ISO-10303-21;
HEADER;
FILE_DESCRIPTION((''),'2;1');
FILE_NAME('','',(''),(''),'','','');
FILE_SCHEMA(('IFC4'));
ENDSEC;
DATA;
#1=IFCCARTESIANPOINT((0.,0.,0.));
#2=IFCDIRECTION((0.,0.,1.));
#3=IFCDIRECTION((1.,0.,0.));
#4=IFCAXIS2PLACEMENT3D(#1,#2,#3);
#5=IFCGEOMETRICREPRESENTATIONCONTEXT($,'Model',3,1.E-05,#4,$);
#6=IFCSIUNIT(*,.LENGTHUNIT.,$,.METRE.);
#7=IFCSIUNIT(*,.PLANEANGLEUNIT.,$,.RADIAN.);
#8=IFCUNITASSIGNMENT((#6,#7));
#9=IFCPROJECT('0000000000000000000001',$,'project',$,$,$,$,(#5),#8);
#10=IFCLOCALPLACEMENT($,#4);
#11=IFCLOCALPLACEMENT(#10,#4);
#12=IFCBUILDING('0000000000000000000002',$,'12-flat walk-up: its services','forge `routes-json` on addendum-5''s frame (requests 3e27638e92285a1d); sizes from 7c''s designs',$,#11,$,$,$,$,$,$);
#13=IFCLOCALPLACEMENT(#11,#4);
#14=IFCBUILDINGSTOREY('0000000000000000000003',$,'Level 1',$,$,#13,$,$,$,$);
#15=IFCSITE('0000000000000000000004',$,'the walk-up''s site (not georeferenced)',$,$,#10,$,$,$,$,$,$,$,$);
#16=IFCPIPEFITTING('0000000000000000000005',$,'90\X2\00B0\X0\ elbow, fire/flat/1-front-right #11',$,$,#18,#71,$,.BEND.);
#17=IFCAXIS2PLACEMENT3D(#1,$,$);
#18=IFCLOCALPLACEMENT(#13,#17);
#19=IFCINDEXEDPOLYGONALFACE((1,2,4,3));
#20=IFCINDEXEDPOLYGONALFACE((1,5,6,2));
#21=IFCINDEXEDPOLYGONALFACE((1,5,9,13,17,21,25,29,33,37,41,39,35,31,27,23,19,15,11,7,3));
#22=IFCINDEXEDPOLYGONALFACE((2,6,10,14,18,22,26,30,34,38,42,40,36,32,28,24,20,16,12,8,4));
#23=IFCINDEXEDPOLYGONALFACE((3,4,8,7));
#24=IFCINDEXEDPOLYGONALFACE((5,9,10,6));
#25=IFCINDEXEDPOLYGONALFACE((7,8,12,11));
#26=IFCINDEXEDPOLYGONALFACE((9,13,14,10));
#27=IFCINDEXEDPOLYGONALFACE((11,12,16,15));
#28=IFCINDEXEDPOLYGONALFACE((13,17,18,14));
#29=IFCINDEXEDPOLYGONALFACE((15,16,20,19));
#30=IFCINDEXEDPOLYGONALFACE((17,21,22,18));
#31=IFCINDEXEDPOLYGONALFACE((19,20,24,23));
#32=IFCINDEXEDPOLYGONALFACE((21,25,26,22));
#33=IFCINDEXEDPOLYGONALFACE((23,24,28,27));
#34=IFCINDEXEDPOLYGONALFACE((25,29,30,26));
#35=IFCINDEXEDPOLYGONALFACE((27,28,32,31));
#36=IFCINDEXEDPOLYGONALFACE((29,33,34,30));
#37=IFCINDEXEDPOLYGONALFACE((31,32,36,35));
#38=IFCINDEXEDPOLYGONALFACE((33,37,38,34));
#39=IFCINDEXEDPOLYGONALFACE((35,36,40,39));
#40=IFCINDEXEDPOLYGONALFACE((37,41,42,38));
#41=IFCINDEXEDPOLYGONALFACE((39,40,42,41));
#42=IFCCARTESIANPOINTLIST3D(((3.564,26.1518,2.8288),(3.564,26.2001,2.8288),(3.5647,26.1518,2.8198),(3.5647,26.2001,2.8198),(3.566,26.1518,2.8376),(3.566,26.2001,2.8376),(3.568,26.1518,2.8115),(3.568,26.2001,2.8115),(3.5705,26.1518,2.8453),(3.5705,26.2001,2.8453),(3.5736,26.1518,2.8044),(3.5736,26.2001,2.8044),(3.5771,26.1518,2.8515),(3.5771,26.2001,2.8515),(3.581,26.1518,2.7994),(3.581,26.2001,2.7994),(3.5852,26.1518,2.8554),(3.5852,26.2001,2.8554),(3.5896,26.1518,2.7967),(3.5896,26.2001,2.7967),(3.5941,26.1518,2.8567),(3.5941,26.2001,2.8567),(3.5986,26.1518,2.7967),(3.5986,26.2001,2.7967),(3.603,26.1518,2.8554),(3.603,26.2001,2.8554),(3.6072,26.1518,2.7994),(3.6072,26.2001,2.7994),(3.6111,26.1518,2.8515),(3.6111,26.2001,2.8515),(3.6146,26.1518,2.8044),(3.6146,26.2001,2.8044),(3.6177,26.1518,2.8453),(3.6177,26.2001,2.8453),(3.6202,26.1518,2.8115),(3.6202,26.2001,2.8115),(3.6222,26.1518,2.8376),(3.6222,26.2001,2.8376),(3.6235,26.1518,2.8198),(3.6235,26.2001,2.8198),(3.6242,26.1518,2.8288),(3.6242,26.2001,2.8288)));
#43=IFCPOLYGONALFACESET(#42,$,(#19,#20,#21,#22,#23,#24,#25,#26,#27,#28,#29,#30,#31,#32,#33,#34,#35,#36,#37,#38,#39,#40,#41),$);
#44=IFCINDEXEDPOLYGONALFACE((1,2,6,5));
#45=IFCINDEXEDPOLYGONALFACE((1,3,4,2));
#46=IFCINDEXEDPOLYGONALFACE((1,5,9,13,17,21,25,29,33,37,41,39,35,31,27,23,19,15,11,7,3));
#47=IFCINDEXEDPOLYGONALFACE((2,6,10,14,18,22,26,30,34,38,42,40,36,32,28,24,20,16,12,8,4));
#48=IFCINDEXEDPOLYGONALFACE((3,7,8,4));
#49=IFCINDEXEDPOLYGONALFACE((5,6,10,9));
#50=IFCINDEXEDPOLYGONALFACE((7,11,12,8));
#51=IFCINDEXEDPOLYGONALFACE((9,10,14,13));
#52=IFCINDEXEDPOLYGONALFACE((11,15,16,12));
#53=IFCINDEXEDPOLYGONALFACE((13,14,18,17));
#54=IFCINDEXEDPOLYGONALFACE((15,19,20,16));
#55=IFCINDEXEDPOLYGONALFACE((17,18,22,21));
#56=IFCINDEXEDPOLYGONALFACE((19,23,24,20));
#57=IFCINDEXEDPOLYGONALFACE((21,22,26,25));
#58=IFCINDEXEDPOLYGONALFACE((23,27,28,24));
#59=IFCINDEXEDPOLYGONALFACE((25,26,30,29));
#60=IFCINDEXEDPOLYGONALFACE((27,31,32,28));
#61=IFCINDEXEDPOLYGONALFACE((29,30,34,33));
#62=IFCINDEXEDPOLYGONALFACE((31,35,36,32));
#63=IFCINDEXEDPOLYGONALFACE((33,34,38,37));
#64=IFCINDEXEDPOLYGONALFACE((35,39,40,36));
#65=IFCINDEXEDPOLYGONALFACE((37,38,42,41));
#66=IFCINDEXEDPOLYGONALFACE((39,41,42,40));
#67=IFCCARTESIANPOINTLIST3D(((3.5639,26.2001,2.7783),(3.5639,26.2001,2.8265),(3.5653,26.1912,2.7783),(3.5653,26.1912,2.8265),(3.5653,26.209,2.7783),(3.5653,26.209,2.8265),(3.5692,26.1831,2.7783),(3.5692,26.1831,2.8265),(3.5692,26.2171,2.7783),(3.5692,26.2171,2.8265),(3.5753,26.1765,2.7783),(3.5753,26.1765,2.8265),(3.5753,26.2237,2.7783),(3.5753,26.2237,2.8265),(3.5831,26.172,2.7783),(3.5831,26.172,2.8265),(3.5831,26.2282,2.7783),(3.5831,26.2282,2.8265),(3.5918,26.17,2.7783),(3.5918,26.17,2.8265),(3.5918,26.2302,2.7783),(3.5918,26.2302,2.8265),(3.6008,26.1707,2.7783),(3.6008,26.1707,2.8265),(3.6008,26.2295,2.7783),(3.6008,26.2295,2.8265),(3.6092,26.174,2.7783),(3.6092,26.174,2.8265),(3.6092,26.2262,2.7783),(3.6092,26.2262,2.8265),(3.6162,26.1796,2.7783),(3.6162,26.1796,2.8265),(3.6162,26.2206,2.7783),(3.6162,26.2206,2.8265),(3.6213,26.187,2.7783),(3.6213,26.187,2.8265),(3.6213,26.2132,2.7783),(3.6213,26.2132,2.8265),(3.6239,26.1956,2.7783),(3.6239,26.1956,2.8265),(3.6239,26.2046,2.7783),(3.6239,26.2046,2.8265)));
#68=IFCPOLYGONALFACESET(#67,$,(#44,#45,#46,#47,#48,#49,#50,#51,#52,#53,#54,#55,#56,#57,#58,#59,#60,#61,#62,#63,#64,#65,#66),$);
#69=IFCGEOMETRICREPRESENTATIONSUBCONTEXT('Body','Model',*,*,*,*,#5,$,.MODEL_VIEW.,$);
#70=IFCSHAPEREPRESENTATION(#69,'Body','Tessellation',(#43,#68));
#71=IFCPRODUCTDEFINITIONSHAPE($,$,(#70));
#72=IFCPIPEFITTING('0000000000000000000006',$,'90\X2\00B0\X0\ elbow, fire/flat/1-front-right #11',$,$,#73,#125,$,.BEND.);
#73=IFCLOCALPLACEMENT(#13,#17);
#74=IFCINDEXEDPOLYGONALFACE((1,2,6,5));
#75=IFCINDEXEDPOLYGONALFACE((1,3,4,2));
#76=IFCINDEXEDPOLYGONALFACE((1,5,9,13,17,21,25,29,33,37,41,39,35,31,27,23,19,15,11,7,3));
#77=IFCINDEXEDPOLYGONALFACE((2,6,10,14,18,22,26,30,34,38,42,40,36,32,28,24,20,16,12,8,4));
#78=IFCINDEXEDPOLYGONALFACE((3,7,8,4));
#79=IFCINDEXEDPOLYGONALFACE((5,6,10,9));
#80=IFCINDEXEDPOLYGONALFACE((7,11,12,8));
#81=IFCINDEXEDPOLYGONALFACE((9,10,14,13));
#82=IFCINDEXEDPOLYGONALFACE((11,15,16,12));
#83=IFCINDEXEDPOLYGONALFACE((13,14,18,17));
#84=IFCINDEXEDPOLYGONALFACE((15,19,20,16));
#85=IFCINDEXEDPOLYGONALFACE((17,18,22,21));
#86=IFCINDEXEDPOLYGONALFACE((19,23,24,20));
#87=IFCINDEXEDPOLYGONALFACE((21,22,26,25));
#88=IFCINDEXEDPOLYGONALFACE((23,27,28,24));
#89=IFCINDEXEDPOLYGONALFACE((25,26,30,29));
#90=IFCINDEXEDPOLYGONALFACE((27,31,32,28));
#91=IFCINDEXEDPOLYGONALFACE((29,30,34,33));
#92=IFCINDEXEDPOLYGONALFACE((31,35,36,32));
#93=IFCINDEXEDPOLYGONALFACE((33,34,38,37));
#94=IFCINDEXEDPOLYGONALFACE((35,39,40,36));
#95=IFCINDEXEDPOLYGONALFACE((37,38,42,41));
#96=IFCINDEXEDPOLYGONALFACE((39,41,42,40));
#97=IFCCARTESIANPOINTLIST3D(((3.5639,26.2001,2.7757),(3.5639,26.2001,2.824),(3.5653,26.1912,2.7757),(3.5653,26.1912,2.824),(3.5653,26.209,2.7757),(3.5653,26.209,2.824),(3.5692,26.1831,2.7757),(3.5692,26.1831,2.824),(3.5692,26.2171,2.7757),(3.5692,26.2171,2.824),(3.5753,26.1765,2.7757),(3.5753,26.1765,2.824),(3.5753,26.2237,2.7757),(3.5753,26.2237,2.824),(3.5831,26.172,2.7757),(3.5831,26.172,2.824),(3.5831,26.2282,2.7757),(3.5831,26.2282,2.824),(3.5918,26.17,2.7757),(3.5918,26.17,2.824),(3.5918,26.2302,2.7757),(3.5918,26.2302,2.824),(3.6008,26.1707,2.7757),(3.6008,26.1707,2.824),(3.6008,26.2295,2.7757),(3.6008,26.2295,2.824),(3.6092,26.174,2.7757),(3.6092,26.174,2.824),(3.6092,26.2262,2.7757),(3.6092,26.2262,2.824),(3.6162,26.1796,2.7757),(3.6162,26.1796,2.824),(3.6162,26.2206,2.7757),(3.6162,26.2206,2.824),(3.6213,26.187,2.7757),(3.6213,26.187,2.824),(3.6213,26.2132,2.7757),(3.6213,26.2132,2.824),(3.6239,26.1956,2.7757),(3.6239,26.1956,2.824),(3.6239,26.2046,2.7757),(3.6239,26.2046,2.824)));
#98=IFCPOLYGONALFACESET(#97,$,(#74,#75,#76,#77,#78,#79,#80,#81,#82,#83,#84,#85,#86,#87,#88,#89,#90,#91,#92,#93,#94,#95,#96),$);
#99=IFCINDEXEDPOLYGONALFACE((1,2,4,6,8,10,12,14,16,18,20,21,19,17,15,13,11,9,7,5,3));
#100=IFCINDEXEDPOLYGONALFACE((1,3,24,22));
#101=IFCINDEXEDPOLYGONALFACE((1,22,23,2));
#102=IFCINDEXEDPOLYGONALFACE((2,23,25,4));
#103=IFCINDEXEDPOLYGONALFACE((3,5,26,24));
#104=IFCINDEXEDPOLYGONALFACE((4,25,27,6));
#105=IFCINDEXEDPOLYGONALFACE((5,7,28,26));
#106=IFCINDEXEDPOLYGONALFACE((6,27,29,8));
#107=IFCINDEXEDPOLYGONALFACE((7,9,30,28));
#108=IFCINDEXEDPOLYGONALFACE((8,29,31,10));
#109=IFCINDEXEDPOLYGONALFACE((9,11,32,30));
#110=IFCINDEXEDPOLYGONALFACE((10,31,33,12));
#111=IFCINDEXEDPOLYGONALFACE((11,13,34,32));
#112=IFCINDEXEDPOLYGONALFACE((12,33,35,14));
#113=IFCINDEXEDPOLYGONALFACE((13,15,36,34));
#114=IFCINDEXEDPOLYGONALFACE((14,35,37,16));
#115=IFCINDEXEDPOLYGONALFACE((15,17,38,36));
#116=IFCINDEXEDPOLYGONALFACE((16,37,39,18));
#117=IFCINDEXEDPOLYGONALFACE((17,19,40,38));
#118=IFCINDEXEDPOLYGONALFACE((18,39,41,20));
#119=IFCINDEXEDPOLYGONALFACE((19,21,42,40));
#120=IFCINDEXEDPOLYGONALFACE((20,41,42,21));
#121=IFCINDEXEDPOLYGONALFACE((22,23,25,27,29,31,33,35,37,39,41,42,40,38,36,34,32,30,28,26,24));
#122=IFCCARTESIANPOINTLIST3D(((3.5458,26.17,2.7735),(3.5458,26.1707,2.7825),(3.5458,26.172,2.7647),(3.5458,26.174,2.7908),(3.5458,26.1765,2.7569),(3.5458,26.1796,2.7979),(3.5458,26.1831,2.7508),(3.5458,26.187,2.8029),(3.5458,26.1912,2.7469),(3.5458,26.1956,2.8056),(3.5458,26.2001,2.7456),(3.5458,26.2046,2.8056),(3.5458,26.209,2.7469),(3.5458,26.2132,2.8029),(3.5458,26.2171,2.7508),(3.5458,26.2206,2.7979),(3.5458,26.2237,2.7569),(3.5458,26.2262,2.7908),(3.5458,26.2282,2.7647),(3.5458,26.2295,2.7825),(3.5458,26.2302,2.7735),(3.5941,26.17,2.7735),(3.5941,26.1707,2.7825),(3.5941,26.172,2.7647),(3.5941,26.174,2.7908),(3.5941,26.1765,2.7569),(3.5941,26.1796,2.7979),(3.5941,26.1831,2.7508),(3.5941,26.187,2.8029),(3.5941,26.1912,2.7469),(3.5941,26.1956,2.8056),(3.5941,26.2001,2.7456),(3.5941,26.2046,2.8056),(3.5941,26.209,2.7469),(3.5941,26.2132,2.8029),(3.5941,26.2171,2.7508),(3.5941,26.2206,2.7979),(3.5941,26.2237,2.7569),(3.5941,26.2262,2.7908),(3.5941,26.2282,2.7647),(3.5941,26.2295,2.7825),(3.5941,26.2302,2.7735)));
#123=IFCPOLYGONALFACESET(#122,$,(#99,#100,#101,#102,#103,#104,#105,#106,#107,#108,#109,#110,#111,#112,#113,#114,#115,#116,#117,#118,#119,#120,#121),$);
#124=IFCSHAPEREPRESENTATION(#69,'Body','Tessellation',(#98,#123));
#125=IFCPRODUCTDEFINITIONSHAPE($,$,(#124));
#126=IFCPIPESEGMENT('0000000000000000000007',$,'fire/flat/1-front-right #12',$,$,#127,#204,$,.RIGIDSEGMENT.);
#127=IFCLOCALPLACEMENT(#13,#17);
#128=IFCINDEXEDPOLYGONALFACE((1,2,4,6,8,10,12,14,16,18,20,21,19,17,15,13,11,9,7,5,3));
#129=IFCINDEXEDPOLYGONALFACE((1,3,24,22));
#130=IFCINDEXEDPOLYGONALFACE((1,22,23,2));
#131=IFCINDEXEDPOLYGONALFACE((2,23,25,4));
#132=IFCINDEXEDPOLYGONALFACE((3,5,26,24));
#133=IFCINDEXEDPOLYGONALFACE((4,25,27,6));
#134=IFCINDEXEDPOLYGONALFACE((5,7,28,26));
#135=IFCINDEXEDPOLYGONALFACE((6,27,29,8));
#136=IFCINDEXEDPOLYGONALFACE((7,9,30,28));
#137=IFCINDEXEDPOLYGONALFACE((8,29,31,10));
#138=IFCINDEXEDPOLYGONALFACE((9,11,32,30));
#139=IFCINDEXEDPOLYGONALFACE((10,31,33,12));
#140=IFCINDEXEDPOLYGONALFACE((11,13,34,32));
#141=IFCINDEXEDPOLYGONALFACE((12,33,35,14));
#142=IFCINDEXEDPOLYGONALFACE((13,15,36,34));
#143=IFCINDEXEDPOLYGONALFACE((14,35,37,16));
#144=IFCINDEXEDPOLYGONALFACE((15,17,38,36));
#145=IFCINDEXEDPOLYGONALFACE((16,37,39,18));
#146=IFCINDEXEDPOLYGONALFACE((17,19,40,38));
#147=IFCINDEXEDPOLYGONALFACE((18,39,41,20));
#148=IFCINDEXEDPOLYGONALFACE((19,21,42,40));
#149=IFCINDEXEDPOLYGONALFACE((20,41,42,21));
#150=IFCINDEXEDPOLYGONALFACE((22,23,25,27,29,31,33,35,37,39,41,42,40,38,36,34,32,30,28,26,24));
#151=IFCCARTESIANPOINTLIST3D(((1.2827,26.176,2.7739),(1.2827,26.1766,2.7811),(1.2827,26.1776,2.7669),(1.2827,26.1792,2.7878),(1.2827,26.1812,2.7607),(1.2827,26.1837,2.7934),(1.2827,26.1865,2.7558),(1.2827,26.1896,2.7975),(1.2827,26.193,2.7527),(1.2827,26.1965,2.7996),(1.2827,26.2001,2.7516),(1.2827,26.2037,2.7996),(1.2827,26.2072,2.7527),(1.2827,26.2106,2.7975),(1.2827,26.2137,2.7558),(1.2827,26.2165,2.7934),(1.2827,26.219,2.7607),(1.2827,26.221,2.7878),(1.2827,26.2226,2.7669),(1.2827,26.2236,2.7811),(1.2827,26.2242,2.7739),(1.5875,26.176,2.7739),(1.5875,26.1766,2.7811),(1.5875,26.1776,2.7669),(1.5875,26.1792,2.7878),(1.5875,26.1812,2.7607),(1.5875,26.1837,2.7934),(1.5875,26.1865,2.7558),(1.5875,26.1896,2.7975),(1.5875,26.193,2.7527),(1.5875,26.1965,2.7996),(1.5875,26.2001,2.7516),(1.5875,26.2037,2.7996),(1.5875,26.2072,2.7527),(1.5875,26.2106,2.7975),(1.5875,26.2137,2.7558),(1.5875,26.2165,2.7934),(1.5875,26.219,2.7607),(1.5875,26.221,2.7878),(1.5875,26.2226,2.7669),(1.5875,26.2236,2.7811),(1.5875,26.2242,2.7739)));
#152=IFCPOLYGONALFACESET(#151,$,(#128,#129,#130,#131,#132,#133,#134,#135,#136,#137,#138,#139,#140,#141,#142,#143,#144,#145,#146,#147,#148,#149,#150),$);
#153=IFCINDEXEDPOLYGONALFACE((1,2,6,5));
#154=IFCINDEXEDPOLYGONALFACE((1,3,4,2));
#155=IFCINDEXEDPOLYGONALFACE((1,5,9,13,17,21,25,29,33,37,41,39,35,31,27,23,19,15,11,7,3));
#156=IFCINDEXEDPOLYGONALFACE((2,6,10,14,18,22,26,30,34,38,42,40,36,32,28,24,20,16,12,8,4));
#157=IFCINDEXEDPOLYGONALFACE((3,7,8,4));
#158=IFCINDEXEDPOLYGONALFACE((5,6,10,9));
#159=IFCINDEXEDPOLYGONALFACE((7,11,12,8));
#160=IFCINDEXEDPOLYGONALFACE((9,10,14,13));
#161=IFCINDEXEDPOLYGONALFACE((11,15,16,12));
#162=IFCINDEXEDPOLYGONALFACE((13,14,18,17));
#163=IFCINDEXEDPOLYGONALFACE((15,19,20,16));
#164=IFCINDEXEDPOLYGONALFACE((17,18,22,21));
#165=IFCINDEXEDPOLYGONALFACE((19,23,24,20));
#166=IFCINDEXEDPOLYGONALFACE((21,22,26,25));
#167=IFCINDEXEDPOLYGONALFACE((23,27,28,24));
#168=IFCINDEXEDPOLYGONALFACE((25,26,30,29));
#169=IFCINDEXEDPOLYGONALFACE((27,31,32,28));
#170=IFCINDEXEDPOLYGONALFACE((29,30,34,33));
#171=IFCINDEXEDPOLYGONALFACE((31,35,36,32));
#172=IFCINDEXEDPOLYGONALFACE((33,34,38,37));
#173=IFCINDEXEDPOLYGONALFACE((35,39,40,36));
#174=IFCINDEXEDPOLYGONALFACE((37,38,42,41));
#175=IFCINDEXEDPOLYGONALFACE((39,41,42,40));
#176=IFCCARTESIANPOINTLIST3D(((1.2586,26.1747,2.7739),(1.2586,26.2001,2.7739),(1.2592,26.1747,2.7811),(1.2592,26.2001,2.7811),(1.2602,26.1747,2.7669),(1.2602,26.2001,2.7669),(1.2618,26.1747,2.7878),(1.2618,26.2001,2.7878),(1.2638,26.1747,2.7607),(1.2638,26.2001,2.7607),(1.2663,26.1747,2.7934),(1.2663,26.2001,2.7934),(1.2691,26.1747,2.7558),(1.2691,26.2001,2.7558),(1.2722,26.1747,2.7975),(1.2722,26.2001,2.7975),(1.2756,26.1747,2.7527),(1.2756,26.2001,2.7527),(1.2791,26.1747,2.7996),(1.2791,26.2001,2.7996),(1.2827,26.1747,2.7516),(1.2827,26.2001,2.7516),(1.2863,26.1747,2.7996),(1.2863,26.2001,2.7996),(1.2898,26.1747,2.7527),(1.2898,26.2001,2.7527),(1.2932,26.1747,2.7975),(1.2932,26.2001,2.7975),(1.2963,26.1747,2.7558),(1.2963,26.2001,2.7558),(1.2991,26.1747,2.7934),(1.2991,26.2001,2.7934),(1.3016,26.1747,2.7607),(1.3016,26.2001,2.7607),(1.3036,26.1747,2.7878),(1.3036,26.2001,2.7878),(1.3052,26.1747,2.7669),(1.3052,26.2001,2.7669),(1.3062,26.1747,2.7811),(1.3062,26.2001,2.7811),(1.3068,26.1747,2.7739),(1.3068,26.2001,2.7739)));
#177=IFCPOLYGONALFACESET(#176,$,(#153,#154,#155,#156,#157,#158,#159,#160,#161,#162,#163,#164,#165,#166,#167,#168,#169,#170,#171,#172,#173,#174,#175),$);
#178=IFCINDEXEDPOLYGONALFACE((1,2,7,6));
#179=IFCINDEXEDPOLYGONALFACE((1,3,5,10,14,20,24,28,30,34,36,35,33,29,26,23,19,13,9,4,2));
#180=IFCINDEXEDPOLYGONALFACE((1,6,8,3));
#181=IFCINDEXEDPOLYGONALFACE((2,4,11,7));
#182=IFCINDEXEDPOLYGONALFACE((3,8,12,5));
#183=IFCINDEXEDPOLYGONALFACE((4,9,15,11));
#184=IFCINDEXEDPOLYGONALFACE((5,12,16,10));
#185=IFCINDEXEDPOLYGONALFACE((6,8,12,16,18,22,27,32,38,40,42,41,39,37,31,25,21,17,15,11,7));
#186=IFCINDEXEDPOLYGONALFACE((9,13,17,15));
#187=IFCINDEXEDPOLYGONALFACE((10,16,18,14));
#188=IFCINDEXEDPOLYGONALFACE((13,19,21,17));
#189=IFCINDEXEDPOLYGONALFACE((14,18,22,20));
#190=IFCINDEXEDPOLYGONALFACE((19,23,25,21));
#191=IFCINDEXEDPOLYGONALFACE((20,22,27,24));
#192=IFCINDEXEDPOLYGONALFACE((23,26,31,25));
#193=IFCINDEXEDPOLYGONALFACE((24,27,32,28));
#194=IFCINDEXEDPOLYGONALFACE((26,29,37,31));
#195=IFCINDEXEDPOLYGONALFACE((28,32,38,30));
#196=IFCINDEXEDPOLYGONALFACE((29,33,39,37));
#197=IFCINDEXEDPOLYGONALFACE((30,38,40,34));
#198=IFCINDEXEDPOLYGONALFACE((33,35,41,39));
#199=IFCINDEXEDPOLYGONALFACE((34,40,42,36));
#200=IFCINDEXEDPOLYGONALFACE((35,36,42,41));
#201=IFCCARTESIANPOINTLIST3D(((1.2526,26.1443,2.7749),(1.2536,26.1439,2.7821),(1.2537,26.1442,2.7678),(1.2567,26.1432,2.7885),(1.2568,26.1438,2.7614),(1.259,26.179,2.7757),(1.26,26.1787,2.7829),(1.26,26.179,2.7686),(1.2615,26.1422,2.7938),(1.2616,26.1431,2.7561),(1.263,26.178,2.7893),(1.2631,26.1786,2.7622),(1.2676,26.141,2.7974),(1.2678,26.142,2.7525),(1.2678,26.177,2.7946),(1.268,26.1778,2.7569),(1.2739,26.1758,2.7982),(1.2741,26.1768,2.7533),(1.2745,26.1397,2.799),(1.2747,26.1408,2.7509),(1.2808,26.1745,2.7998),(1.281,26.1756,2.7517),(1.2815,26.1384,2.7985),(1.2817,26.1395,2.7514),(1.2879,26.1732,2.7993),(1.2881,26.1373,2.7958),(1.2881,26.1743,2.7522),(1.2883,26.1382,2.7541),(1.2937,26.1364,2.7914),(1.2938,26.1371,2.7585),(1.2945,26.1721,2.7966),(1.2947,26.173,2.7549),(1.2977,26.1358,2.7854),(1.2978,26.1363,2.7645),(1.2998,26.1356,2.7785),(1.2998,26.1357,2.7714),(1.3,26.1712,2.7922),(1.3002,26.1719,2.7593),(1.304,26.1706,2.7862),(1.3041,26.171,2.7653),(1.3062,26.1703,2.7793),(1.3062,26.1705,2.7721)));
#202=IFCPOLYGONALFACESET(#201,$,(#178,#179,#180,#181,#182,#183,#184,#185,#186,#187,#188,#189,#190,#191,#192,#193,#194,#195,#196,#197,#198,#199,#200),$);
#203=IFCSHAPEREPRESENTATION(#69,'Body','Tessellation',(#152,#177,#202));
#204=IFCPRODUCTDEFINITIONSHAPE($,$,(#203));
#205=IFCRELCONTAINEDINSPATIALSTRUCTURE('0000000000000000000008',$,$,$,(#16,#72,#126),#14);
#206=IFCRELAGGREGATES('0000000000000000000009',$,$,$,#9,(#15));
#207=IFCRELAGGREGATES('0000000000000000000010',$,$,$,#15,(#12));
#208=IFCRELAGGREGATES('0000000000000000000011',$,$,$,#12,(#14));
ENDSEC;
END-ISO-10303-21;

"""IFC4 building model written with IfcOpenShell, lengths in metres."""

from ifc_helpers import new_model, entity, si_unit, frame, origin_with_axes, place, context, subcontext, project, spatial, element, save


model = new_model("IFC4")

# Units and contexts
model_context = context("Model", 3, precision=1e-05, world=origin_with_axes())
body_context = subcontext(model_context, "Body", "Model", "MODEL_VIEW")
ifc_project = project(units=[si_unit("LENGTHUNIT", "METRE"), si_unit("PLANEANGLEUNIT", "RADIAN")], contexts=[model_context])

# Site, building, storey
site_placement = place(None, origin_with_axes())
site = spatial("IfcSite", under=ifc_project, at=site_placement, Name="the walk-up's site (not georeferenced)")
building_placement = place(site_placement, origin_with_axes())
building = spatial("IfcBuilding", under=site, at=building_placement, Name="12-flat walk-up: its services", Description="forge `routes-json` on addendum-5's frame (requests 3e27638e92285a1d); sizes from 7c's designs")
storey_placement = place(building_placement, origin_with_axes())
storey = spatial("IfcBuildingStorey", under=building, at=storey_placement, Name="Level 1")

# Pipe fittings
pipe_fitting_1_placement = place(storey_placement, frame((3.5941, 26.1518, 2.8265), z_axis=(0.0, 0.0, 1.0), x_axis=(1.0, 0.0, 0.0)))
element("IfcPipeFitting", 1, at=pipe_fitting_1_placement, inside=storey, Name="90° elbow, fire/flat/1-front-right #11", PredefinedType="BEND", context=body_context, shape_type="AdvancedSweptSolid", body=[
    entity("IfcSweptDiskSolid", entity("IfcPolyline", [entity("IfcCartesianPoint", [0.0, 0.0, 0.0]), entity("IfcCartesianPoint", [0.0, 0.0483, 0.0])]), 0.0302),
    entity("IfcSweptDiskSolid", entity("IfcPolyline", [entity("IfcCartesianPoint", [0.0, 0.0483, 0.0]), entity("IfcCartesianPoint", [0.0, 0.0483, -0.0483])]), 0.0302),
])
pipe_fitting_2_placement = place(storey_placement, frame((3.5941, 26.2001, 2.824), z_axis=(0.0, 0.0, 1.0), x_axis=(1.0, 0.0, 0.0)))
element("IfcPipeFitting", 2, at=pipe_fitting_2_placement, inside=storey, Name="90° elbow, fire/flat/1-front-right #11", PredefinedType="BEND", context=body_context, shape_type="AdvancedSweptSolid", body=[
    entity("IfcSweptDiskSolid", entity("IfcPolyline", [entity("IfcCartesianPoint", [0.0, 0.0, 0.0]), entity("IfcCartesianPoint", [0.0, 0.0, -0.0483])]), 0.0302),
    entity("IfcSweptDiskSolid", entity("IfcPolyline", [entity("IfcCartesianPoint", [0.0, 0.0, -0.0483]), entity("IfcCartesianPoint", [-0.0483, 0.0, -0.0483])]), 0.0302),
])

# Pipe segment
pipe_segment_1_placement = place(storey_placement, frame((1.5875, 26.2001, 2.7757), z_axis=(0.0, 0.0, 1.0), x_axis=(1.0, 0.0, 0.0)))
element("IfcPipeSegment", 3, at=pipe_segment_1_placement, inside=storey, Name="fire/flat/1-front-right #12", PredefinedType="RIGIDSEGMENT", context=body_context, shape_type="AdvancedSweptSolid", body=[
    entity("IfcSweptDiskSolid", entity("IfcPolyline", [entity("IfcCartesianPoint", [0.0, 0.0, 0.0]), entity("IfcCartesianPoint", [-0.3048, 0.0, 0.0])]), 0.0241),
    entity("IfcSweptDiskSolid", entity("IfcPolyline", [entity("IfcCartesianPoint", [-0.3048, 0.0, 0.0]), entity("IfcCartesianPoint", [-0.3048, -0.0254, 0.0])]), 0.0241),
    entity("IfcSweptDiskSolid", entity("IfcPolyline", [entity("IfcCartesianPoint", [-0.3048, -0.0254, 0.0]), entity("IfcCartesianPoint", [-0.3111, -0.0602, -0.0008])]), 0.0241),
])

save(model, "model.ifc")
